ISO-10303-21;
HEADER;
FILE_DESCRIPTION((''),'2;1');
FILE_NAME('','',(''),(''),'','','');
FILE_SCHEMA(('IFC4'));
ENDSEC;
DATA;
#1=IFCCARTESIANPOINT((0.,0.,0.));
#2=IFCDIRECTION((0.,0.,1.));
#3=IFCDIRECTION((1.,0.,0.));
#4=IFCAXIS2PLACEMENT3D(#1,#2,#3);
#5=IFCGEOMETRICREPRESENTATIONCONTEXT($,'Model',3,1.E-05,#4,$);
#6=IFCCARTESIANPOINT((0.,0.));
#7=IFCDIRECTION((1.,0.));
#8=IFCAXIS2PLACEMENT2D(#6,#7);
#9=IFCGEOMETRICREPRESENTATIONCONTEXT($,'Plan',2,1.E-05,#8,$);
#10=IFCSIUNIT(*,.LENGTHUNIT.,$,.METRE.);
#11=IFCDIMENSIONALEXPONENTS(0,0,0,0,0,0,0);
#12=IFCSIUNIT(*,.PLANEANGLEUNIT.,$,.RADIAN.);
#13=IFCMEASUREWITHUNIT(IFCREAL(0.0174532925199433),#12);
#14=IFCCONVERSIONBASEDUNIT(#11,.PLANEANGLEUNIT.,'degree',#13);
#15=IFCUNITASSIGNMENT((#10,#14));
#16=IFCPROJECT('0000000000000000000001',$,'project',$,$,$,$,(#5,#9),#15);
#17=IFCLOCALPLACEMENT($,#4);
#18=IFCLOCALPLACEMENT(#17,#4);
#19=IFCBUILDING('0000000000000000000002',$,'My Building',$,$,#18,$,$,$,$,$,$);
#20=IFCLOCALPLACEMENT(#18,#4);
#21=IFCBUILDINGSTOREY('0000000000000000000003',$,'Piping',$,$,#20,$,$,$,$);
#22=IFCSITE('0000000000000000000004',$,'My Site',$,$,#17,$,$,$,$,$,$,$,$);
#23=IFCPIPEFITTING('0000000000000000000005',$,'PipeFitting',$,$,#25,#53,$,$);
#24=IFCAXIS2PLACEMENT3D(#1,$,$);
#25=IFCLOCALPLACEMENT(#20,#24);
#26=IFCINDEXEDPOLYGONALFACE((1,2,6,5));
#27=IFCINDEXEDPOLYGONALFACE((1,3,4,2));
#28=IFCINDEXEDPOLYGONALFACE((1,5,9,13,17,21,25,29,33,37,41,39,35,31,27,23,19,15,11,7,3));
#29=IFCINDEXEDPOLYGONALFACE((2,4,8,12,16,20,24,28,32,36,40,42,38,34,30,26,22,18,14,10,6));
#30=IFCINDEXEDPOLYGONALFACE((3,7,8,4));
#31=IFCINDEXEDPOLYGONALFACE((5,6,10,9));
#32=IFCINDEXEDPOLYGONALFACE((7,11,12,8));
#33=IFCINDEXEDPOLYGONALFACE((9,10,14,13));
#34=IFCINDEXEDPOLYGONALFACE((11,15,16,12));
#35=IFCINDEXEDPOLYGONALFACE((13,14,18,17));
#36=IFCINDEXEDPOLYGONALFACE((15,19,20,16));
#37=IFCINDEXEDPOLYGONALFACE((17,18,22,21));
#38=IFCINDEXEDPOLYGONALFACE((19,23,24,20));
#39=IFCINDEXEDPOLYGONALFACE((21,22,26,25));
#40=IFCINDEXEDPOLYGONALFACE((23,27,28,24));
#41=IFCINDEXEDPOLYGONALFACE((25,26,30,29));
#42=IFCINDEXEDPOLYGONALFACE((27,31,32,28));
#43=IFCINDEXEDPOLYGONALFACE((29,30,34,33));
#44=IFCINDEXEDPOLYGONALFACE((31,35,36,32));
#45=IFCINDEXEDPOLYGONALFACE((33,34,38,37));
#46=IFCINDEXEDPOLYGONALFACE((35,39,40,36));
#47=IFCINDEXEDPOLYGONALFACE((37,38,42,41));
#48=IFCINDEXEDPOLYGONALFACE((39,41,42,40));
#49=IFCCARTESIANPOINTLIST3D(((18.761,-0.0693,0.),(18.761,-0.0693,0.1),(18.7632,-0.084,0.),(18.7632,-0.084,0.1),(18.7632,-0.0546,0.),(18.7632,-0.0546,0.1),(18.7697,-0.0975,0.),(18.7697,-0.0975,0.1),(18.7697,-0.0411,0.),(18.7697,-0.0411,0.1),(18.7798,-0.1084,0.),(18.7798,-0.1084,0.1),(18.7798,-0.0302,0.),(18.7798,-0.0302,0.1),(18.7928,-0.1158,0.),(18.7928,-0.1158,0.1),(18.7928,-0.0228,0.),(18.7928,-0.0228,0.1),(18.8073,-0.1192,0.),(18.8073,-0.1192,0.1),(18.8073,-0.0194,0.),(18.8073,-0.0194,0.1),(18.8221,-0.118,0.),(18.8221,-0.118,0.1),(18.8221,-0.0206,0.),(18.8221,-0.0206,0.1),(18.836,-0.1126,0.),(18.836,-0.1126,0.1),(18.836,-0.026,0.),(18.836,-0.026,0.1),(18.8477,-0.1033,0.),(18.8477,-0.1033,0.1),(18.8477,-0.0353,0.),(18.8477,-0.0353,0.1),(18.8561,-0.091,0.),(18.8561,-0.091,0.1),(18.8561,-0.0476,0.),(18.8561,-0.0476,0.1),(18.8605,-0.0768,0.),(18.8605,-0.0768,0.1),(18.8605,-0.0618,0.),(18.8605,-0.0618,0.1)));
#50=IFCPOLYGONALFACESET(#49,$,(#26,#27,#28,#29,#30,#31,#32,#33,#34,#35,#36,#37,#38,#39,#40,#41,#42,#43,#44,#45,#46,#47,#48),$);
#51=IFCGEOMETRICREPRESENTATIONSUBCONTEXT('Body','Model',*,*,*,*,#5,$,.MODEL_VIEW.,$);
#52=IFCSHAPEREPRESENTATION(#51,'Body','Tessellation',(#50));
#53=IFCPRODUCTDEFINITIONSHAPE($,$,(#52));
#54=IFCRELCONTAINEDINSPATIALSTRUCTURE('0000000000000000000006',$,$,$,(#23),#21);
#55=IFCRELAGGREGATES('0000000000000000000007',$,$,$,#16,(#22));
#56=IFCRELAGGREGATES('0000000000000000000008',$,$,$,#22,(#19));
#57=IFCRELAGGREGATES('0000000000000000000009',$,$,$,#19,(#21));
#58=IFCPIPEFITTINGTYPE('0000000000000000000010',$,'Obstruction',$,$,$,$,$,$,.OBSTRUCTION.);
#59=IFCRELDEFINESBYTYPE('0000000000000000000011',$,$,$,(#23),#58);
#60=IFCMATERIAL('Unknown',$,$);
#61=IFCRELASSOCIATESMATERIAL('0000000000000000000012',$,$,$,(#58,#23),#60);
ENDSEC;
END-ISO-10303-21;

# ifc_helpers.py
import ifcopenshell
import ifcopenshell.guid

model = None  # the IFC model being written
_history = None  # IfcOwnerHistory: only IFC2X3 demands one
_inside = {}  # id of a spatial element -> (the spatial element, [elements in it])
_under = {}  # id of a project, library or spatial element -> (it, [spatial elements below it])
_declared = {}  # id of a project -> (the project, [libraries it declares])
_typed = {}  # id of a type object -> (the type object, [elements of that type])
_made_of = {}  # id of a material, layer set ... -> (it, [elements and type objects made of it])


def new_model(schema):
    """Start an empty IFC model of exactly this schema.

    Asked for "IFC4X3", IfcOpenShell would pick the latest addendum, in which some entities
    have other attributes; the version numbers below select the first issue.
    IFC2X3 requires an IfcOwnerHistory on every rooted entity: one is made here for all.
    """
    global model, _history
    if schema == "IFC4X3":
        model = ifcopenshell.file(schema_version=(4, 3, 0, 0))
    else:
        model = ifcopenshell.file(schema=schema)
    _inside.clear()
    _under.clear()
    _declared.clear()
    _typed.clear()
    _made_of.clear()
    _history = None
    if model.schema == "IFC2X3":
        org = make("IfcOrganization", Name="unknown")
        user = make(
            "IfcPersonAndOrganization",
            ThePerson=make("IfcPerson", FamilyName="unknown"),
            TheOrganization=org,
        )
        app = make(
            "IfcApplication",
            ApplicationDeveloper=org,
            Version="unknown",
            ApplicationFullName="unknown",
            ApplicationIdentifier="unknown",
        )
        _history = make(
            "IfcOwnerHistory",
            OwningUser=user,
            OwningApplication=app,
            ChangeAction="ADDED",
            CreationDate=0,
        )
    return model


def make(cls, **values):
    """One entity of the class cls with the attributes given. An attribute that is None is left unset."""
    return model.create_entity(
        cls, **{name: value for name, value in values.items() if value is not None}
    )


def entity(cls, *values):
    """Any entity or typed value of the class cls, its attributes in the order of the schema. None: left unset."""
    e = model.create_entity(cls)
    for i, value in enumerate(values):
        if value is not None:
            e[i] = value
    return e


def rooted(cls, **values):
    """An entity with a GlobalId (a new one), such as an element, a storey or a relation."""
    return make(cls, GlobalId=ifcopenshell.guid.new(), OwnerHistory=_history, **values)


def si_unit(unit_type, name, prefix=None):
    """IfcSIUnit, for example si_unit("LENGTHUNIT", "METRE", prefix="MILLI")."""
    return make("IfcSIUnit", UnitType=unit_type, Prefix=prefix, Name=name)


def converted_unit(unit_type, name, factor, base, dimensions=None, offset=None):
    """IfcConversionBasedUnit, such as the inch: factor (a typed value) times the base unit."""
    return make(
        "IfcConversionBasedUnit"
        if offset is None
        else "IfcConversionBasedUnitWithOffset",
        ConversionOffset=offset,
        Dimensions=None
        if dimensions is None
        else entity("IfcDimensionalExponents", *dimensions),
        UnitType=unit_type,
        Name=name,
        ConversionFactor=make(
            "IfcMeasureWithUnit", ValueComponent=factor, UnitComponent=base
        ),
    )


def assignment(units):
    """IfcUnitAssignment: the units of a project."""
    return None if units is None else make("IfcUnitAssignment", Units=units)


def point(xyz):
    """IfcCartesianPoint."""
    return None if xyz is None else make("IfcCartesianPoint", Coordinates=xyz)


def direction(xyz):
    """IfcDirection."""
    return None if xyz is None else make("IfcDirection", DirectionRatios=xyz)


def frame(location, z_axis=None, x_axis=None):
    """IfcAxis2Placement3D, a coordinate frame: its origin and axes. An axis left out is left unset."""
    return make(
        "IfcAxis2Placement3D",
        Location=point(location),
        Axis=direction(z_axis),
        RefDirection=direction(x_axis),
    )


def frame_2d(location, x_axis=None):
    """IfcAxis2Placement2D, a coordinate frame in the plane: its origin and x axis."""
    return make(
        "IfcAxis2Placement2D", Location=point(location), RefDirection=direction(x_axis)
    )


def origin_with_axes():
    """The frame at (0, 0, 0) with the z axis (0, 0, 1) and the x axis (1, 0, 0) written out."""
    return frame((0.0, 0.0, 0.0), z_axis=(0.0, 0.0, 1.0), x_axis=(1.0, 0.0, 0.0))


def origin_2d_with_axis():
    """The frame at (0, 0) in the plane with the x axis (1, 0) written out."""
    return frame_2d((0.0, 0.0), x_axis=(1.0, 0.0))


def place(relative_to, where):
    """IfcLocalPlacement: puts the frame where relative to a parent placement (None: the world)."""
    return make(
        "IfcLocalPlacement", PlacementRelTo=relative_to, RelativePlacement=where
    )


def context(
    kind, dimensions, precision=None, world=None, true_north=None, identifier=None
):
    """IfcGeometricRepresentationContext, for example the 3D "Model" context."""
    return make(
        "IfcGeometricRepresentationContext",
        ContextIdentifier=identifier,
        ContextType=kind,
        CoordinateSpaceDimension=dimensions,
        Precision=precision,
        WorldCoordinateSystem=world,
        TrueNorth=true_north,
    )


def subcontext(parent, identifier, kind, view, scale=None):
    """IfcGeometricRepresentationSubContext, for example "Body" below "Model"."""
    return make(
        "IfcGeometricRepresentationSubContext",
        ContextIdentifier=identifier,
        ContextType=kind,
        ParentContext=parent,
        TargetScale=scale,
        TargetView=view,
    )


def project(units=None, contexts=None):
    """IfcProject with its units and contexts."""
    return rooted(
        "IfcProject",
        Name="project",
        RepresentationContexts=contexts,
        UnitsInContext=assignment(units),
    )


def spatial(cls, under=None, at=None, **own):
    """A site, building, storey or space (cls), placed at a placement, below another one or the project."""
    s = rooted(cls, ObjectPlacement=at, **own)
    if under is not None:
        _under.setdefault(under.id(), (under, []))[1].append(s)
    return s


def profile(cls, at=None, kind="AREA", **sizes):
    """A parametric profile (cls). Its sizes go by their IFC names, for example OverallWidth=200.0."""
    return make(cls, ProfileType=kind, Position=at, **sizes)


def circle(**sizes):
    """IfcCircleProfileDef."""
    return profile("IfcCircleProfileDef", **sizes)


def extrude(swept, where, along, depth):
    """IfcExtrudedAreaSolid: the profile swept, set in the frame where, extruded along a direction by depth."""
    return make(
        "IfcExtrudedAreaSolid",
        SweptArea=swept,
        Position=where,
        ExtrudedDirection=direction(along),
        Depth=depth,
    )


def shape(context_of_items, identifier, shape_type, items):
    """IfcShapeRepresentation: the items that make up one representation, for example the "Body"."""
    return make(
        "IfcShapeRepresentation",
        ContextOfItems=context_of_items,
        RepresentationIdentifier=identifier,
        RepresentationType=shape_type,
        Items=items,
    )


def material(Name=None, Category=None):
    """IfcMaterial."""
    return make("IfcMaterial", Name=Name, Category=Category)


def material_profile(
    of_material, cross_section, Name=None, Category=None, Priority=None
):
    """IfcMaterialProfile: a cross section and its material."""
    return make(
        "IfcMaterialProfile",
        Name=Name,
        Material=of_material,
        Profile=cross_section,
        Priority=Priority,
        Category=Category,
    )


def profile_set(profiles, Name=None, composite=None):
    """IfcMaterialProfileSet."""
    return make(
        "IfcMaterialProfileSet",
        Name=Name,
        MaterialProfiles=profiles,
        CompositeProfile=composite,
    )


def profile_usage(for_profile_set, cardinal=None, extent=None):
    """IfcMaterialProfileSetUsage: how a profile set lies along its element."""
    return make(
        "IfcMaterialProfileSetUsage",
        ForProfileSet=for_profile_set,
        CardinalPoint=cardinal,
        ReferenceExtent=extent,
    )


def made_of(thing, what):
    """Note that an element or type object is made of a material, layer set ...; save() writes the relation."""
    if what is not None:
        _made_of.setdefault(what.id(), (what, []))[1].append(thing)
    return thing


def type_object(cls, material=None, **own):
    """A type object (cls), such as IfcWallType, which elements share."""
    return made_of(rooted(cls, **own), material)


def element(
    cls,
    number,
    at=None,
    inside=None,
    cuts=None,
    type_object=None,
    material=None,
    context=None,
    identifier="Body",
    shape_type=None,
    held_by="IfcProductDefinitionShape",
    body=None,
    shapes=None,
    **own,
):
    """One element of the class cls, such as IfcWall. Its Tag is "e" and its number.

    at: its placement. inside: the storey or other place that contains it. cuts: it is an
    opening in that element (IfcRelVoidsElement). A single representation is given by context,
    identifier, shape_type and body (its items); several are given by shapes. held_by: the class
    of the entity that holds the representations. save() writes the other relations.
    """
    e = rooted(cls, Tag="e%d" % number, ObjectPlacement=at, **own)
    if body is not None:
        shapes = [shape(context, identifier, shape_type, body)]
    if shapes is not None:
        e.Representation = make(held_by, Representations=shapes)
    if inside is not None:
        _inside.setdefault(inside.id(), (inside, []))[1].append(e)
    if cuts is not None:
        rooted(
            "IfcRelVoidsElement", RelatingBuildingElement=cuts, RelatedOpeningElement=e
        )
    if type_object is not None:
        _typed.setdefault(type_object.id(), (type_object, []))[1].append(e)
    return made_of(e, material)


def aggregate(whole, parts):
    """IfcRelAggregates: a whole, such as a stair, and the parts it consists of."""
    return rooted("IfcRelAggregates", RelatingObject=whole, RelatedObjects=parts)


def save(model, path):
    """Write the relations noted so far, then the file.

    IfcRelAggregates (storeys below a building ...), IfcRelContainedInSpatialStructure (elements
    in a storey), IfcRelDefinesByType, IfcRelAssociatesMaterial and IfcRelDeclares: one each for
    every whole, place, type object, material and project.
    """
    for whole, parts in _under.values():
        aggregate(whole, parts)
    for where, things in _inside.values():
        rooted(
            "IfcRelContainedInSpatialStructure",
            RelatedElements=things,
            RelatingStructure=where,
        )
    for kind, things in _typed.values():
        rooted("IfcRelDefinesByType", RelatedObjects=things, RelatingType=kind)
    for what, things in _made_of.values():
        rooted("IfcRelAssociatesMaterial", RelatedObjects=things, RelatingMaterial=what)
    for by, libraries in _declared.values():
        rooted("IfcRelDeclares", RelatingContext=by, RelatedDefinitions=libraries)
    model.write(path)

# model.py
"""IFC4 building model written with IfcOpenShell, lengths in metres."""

from ifc_helpers import new_model, entity, si_unit, converted_unit, frame, origin_with_axes, origin_2d_with_axis, place, context, subcontext, project, spatial, circle, extrude, material, material_profile, profile_set, profile_usage, type_object, element, save


model = new_model("IFC4")

# Units and contexts
model_context = context("Model", 3, precision=1e-05, world=origin_with_axes())
plan_context = context("Plan", 2, precision=1e-05, world=origin_2d_with_axis())
body_context = subcontext(model_context, "Body", "Model", "MODEL_VIEW")
ifc_project = project(units=[si_unit("LENGTHUNIT", "METRE"), converted_unit("PLANEANGLEUNIT", "degree", entity("IfcReal", 0.0174532925199433), si_unit("PLANEANGLEUNIT", "RADIAN"), dimensions=[0, 0, 0, 0, 0, 0, 0])], contexts=[model_context, plan_context])

# Site, building, storey
site_placement = place(None, origin_with_axes())
site = spatial("IfcSite", under=ifc_project, at=site_placement, Name="My Site")
building_placement = place(site_placement, origin_with_axes())
building = spatial("IfcBuilding", under=site, at=building_placement, Name="My Building")
storey_placement = place(building_placement, origin_with_axes())
storey = spatial("IfcBuildingStorey", under=building, at=storey_placement, Name="Piping")

# Shared definitions
ifc_material = material(Name="Unknown")

# Pipe fitting
ifc_material_profile_1 = material_profile(ifc_material, circle(Radius=0.05))
ifc_profile_set_1 = profile_set([ifc_material_profile_1])
ifc_profile_usage_1 = profile_usage(ifc_profile_set_1, cardinal=5)
pipe_fitting_type_1 = type_object("IfcPipeFittingType", Name="Obstruction", PredefinedType="OBSTRUCTION", material=ifc_profile_set_1)
pipe_fitting_placement = place(storey_placement, frame((18.811, -0.0693, 0.1), z_axis=(0.0, 0.0, -1.0), x_axis=(-1.0, 0.0, 0.0)))
element("IfcPipeFitting", 1, at=pipe_fitting_placement, inside=storey, type_object=pipe_fitting_type_1, material=ifc_profile_usage_1, Name="PipeFitting", context=body_context, shape_type="SweptSolid", body=[
    extrude(circle(Radius=0.05), origin_with_axes(), (0.0, 0.0, 1.0), 0.1),
])

save(model, "model.ifc")
